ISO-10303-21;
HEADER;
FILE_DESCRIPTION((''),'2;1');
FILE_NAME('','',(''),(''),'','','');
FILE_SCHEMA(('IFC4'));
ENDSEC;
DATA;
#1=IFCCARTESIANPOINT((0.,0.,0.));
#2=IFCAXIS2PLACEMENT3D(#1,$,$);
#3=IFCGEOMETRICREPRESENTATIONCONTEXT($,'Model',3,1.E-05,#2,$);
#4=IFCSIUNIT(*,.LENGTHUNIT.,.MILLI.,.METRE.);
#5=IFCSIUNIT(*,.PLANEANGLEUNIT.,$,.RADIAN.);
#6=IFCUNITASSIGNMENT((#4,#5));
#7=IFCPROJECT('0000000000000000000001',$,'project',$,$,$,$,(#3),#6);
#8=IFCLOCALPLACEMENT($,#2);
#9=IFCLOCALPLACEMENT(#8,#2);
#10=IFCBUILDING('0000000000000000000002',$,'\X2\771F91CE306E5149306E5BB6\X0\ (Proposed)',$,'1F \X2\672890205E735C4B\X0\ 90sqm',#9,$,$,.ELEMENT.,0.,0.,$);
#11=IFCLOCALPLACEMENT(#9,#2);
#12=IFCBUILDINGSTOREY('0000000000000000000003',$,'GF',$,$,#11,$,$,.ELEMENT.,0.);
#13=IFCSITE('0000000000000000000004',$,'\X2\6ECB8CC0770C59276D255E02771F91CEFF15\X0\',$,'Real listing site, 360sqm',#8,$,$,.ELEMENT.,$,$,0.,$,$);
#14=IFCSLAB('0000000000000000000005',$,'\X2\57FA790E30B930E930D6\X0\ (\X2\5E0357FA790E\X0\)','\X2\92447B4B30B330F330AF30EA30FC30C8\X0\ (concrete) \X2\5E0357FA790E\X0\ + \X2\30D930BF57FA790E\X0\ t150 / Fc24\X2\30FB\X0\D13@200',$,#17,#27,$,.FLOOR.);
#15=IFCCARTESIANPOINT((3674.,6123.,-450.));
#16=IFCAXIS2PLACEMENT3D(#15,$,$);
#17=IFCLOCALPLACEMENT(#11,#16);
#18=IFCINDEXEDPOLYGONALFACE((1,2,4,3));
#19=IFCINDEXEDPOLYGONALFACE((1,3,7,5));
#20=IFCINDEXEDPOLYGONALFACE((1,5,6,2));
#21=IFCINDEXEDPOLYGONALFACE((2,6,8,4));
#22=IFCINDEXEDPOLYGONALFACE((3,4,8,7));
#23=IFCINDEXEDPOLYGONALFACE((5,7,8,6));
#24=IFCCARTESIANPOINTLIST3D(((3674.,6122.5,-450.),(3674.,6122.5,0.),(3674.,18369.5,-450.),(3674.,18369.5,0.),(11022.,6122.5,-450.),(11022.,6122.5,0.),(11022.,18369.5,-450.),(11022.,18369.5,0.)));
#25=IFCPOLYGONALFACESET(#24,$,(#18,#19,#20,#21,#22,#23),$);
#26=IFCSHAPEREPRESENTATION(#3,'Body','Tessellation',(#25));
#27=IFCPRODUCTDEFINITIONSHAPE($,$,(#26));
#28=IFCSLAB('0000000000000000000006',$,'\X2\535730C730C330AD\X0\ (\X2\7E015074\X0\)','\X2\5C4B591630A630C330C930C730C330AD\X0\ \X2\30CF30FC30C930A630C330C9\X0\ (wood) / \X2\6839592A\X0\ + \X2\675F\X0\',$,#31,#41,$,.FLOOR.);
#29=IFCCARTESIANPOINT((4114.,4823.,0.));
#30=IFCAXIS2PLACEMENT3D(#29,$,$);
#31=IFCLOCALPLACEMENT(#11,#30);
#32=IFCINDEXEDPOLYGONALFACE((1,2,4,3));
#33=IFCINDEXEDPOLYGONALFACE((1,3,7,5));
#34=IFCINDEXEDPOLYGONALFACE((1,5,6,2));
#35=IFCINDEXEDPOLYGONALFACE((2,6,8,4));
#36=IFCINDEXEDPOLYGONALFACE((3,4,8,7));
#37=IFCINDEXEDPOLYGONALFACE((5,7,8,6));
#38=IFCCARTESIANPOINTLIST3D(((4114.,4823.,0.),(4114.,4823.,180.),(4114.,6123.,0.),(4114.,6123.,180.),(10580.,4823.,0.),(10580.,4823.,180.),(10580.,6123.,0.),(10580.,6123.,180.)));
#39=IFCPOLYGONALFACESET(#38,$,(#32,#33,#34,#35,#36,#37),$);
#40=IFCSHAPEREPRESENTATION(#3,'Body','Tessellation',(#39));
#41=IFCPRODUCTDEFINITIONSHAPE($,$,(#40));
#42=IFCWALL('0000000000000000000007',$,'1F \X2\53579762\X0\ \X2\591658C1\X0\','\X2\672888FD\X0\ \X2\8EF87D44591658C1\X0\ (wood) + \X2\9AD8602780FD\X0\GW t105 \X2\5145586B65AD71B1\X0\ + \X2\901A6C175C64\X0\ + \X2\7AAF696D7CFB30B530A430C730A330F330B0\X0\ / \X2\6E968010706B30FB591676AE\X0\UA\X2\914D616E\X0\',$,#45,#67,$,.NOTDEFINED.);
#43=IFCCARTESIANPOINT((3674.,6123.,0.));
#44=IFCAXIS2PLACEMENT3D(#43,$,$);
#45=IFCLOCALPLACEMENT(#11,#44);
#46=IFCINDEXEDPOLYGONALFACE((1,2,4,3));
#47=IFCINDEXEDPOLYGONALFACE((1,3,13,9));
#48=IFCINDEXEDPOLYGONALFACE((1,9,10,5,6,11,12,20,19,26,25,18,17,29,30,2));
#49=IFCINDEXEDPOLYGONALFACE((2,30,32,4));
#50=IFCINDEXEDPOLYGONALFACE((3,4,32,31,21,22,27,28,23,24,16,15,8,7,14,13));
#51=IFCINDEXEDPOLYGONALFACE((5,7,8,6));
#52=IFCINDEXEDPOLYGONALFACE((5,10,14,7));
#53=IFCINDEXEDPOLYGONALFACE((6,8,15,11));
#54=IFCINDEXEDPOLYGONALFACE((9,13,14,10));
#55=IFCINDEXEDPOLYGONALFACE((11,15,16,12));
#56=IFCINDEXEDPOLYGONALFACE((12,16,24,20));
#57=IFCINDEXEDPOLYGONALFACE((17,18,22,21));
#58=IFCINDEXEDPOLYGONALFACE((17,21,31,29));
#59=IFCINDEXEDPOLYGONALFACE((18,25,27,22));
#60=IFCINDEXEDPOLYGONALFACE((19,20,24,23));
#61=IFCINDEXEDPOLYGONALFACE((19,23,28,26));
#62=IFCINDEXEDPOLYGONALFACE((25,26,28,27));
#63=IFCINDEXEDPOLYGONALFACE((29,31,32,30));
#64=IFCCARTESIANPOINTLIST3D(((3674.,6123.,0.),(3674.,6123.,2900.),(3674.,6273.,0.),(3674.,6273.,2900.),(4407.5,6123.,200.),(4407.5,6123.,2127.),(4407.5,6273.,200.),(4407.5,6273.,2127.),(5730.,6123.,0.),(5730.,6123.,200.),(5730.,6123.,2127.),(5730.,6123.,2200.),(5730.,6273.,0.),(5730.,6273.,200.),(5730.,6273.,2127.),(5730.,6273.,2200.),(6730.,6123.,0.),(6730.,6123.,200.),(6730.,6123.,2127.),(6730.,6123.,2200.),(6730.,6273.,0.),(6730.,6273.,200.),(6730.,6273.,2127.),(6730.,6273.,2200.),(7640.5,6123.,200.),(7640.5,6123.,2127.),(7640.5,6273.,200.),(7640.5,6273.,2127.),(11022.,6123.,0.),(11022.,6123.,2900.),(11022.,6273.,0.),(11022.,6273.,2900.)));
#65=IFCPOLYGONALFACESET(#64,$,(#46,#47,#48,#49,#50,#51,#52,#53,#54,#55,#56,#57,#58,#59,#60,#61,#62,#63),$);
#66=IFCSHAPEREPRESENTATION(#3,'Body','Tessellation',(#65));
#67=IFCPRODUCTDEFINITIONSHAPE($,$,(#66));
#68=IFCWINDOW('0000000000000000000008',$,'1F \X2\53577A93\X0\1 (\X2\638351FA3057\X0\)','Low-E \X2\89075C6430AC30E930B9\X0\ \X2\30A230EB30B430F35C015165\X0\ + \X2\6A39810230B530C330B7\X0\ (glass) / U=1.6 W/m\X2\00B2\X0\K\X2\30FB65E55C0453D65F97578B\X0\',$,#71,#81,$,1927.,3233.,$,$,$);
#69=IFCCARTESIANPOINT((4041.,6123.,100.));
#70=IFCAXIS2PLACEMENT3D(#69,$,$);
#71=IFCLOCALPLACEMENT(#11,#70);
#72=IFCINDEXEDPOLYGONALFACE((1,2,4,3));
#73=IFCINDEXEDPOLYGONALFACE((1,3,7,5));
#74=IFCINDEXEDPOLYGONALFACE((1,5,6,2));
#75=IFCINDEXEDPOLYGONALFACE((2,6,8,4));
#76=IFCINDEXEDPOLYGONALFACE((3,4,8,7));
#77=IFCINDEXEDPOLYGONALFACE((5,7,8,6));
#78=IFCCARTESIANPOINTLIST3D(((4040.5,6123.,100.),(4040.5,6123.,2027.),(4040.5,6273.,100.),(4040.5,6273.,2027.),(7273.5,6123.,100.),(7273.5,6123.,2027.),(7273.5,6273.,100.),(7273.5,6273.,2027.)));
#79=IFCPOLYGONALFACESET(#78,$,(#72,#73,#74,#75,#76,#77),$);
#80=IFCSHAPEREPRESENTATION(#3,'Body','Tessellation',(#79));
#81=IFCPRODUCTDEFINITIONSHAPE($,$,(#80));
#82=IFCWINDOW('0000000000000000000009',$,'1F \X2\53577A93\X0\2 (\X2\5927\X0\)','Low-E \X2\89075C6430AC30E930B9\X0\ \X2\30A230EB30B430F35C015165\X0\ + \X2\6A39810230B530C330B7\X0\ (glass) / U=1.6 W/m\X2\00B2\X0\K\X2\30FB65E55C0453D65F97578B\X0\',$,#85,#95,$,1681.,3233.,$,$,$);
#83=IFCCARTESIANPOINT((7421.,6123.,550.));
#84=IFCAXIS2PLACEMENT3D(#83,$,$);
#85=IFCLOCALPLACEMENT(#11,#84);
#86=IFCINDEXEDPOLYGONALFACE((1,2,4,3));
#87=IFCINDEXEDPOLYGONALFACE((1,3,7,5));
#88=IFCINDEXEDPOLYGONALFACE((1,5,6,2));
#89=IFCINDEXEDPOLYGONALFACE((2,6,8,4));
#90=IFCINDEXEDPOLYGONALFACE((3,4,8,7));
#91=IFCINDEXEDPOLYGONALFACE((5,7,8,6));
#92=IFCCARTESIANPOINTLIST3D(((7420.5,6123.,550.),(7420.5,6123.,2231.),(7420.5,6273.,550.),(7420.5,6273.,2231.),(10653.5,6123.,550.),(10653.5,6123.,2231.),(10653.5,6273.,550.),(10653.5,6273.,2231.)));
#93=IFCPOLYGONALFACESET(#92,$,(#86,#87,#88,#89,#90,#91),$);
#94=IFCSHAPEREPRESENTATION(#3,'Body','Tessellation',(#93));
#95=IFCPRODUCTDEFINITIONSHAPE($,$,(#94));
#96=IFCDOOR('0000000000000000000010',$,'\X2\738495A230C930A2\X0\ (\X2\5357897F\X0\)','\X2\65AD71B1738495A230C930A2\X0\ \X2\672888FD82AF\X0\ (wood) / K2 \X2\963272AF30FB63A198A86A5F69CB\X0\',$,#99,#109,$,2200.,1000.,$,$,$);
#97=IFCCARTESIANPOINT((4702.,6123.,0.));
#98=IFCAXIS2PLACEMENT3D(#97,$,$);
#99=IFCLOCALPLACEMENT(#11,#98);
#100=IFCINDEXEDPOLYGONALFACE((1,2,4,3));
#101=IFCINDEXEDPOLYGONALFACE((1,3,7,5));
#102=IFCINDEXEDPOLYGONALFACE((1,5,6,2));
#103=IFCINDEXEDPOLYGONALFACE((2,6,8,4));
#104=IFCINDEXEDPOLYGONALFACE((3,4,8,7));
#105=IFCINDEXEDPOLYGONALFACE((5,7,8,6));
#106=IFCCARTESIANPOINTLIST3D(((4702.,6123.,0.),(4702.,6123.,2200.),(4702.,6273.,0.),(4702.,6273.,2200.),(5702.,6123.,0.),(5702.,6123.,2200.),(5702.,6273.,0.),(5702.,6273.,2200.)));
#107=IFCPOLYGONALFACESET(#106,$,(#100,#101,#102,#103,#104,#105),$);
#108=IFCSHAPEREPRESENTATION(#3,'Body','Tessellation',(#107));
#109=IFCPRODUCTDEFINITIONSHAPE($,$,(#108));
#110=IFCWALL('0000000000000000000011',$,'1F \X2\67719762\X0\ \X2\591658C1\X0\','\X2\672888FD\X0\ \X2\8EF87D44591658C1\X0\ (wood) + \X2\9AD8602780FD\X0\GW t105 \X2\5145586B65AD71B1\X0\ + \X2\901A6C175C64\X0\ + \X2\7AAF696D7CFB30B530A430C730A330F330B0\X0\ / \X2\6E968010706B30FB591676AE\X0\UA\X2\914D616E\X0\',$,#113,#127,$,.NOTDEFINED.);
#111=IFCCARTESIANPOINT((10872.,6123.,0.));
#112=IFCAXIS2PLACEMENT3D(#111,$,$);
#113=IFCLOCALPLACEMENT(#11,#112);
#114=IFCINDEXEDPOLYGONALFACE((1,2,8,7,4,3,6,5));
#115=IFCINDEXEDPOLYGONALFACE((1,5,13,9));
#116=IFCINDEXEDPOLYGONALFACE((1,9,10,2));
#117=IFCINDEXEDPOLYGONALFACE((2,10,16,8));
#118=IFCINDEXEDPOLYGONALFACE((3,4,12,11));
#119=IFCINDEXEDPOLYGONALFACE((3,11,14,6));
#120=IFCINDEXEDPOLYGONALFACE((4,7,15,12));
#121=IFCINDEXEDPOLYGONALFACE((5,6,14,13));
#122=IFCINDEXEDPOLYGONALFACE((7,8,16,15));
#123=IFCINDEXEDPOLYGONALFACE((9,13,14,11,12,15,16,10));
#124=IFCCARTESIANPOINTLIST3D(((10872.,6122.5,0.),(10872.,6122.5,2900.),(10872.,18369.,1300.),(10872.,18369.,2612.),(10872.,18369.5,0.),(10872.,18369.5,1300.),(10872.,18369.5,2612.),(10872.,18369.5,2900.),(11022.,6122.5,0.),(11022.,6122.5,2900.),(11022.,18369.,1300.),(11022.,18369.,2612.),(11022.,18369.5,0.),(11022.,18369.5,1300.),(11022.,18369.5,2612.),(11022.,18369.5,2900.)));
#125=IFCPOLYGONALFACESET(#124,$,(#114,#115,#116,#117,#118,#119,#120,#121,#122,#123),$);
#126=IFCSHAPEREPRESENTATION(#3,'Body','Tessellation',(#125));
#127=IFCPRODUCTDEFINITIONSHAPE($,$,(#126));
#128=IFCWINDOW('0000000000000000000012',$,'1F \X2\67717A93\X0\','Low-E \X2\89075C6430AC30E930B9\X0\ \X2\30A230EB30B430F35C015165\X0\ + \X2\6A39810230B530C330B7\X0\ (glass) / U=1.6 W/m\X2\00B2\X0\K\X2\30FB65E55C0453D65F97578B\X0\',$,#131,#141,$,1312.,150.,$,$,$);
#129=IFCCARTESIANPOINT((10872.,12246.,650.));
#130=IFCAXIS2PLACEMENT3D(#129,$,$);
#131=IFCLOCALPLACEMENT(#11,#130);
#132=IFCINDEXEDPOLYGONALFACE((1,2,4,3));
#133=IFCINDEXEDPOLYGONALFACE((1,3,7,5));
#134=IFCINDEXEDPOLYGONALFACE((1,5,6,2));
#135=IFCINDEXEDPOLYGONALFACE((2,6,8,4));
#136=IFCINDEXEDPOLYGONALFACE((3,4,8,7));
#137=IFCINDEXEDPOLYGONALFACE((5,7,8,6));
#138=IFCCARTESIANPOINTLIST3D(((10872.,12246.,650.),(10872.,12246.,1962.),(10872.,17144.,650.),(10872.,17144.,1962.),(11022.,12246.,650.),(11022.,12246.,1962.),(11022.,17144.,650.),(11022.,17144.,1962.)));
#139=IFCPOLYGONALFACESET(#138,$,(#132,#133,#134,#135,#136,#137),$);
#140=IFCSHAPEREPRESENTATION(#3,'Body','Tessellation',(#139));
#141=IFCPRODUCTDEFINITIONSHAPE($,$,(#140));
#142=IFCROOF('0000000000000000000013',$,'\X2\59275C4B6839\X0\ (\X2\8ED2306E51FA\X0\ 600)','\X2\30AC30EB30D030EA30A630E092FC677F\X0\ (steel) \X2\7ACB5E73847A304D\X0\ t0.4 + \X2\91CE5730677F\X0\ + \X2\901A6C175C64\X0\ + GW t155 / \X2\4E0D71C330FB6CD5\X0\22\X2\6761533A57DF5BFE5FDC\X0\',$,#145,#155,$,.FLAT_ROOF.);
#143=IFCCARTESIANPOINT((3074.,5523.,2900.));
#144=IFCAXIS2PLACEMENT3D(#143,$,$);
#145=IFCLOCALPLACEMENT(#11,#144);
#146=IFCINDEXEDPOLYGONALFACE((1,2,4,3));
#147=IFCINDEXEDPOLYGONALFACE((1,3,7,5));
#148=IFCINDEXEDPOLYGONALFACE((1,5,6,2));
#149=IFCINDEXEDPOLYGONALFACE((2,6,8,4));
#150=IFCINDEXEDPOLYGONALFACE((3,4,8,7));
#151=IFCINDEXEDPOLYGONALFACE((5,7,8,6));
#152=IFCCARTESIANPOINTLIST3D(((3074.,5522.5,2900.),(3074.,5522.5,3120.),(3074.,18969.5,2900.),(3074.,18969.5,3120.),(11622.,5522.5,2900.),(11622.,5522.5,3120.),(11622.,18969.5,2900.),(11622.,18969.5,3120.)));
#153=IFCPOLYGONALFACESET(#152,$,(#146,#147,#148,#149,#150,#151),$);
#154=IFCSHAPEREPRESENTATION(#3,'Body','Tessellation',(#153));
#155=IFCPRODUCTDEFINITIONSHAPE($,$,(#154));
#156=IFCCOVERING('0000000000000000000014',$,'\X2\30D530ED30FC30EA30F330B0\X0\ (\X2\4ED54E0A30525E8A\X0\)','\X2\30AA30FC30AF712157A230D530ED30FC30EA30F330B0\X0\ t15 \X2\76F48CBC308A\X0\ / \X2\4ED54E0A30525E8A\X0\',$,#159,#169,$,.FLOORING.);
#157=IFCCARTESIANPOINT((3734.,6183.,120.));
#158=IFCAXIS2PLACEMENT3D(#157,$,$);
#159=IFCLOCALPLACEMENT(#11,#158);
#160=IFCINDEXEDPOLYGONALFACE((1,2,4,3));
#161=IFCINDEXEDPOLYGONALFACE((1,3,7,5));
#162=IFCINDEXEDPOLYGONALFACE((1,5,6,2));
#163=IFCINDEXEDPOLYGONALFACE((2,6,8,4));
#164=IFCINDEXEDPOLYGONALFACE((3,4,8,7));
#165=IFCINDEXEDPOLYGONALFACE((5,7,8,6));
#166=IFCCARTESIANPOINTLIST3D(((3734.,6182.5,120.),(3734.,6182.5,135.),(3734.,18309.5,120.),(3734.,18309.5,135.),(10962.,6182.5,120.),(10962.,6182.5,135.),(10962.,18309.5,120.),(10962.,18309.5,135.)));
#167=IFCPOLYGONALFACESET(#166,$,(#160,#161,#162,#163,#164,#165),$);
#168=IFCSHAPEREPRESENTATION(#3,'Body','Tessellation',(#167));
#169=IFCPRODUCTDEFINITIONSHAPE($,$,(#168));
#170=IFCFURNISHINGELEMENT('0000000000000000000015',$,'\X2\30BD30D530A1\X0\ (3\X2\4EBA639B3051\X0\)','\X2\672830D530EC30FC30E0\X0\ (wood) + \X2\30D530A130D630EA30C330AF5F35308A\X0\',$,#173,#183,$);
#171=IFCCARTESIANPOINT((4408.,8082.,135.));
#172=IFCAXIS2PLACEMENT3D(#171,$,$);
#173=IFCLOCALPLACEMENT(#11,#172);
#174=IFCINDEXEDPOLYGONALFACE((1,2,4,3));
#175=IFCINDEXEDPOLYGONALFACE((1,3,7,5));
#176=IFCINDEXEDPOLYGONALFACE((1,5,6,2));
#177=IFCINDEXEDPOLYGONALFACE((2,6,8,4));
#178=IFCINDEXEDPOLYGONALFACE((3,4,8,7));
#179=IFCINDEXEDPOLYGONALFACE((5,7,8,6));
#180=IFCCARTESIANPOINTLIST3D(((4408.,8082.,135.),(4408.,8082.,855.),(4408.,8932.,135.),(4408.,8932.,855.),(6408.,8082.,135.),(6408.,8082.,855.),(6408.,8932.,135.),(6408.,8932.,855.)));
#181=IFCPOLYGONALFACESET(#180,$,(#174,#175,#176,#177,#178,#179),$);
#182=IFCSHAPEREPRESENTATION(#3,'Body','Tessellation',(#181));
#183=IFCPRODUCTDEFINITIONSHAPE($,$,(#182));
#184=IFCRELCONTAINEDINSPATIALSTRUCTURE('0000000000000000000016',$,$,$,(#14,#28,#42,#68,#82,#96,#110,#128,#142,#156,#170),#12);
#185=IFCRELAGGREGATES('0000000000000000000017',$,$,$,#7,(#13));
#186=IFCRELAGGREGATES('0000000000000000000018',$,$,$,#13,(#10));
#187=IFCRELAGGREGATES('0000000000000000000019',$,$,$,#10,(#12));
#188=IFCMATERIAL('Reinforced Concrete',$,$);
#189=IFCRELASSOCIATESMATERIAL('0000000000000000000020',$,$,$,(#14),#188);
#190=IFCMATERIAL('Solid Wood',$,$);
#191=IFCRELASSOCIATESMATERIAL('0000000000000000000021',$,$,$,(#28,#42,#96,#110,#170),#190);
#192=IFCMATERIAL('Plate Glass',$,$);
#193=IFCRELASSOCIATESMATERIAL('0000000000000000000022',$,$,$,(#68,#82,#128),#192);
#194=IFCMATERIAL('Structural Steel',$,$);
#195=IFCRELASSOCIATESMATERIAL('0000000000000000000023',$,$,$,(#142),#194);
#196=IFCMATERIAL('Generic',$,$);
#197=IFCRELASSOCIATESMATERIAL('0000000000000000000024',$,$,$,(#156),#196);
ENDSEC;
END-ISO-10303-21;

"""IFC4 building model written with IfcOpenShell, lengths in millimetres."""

from ifc_helpers import new_model, si_unit, frame, frame_2d, origin, place, context, project, spatial, rectangle, extrude, material, element, fill, save


model = new_model("IFC4")

# Units and contexts
model_context = context("Model", 3, precision=1e-05, world=origin())
ifc_project = project(units=[si_unit("LENGTHUNIT", "METRE", prefix="MILLI"), si_unit("PLANEANGLEUNIT", "RADIAN")], contexts=[model_context])

# Site, building, storey
site_placement = place(None, origin())
site = spatial("IfcSite", under=ifc_project, at=site_placement, Name="滋賀県大津市真野５", ObjectType="Real listing site, 360sqm", CompositionType="ELEMENT", RefElevation=0.0)
building_placement = place(site_placement, origin())
building = spatial("IfcBuilding", under=site, at=building_placement, Name="真野の光の家 (Proposed)", ObjectType="1F 木造平屋 90sqm", CompositionType="ELEMENT", ElevationOfRefHeight=0.0, ElevationOfTerrain=0.0)
storey_placement = place(building_placement, origin())
storey = spatial("IfcBuildingStorey", under=building, at=storey_placement, Name="GF", CompositionType="ELEMENT", Elevation=0.0)

# Slabs
ifc_material_1 = material(Name="Reinforced Concrete")
slab_1_placement = place(storey_placement, frame((3674.0, 6123.0, -450.0)))
element("IfcSlab", 1, at=slab_1_placement, inside=storey, material=ifc_material_1, Name="基礎スラブ (布基礎)", Description="鉄筋コンクリート (concrete) 布基礎 + ベタ基礎 t150 / Fc24・D13@200", PredefinedType="FLOOR", context=model_context, shape_type="SweptSolid", body=[
    extrude(rectangle(XDim=7348.0, YDim=12247.0, at=frame_2d((3674.0, 6123.0))), frame((3674.0, 6123.0, -450.0)), (0.0, 0.0, 1.0), 450.0),
])
ifc_material_2 = material(Name="Solid Wood")
slab_2_placement = place(storey_placement, frame((4114.0, 4823.0, 0.0)))
element("IfcSlab", 2, at=slab_2_placement, inside=storey, material=ifc_material_2, Name="南デッキ (縁側)", Description="屋外ウッドデッキ ハードウッド (wood) / 根太 + 束", PredefinedType="FLOOR", context=model_context, shape_type="SweptSolid", body=[
    extrude(rectangle(XDim=6466.0, YDim=1300.0, at=frame_2d((3233.0, 650.0))), frame((4114.0, 4823.0, 0.0)), (0.0, 0.0, 1.0), 180.0),
])

# Wall, openings, windows, door
wall_1_placement = place(storey_placement, frame((3674.0, 6123.0, 0.0)))
wall_1 = element("IfcWall", 3, at=wall_1_placement, inside=storey, material=ifc_material_2, Name="1F 南面 外壁", Description="木製 軸組外壁 (wood) + 高性能GW t105 充填断熱 + 通気層 + 窯業系サイディング / 準耐火・外皮UA配慮", PredefinedType="NOTDEFINED", context=model_context, shape_type="SweptSolid", body=[
    extrude(rectangle(XDim=7348.0, YDim=150.0, at=frame_2d((3674.0, 75.0))), frame((3674.0, 6123.0, 0.0)), (0.0, 0.0, 1.0), 2900.0),
])
opening_1_placement = place(storey_placement, frame((4041.0, 6123.0, 100.0)))
opening_1 = element("IfcOpeningElement", 4, at=opening_1_placement, cuts=wall_1, PredefinedType="NOTDEFINED", context=model_context, shape_type="SweptSolid", body=[
    extrude(rectangle(XDim=3233.0, YDim=150.0, at=frame_2d((1616.0, 75.0))), frame((4041.0, 6123.0, 100.0)), (0.0, 0.0, 1.0), 1927.0),
])
opening_2_placement = place(storey_placement, frame((7421.0, 6123.0, 550.0)))
opening_2 = element("IfcOpeningElement", 5, at=opening_2_placement, cuts=wall_1, PredefinedType="NOTDEFINED", context=model_context, shape_type="SweptSolid", body=[
    extrude(rectangle(XDim=3233.0, YDim=150.0, at=frame_2d((1616.0, 75.0))), frame((7421.0, 6123.0, 550.0)), (0.0, 0.0, 1.0), 1681.0),
])
opening_3_placement = place(storey_placement, frame((4702.0, 6123.0, 0.0)))
opening_3 = element("IfcOpeningElement", 6, at=opening_3_placement, cuts=wall_1, PredefinedType="NOTDEFINED", context=model_context, shape_type="SweptSolid", body=[
    extrude(rectangle(XDim=1000.0, YDim=150.0, at=frame_2d((500.0, 75.0))), frame((4702.0, 6123.0, 0.0)), (0.0, 0.0, 1.0), 2200.0),
])
ifc_material_3 = material(Name="Plate Glass")
window_1_placement = place(storey_placement, frame((4041.0, 6123.0, 100.0)))
window_1 = element("IfcWindow", 7, at=window_1_placement, inside=storey, material=ifc_material_3, Name="1F 南窓1 (掃出し)", Description="Low-E 複層ガラス アルゴン封入 + 樹脂サッシ (glass) / U=1.6 W/m²K・日射取得型", OverallHeight=1927.0, OverallWidth=3233.0, context=model_context, shape_type="SweptSolid", body=[
    extrude(rectangle(XDim=3233.0, YDim=150.0, at=frame_2d((1616.0, 75.0))), frame((4041.0, 6123.0, 100.0)), (0.0, 0.0, 1.0), 1927.0),
])
fill(opening_1, window_1)
window_2_placement = place(storey_placement, frame((7421.0, 6123.0, 550.0)))
window_2 = element("IfcWindow", 8, at=window_2_placement, inside=storey, material=ifc_material_3, Name="1F 南窓2 (大)", Description="Low-E 複層ガラス アルゴン封入 + 樹脂サッシ (glass) / U=1.6 W/m²K・日射取得型", OverallHeight=1681.0, OverallWidth=3233.0, context=model_context, shape_type="SweptSolid", body=[
    extrude(rectangle(XDim=3233.0, YDim=150.0, at=frame_2d((1616.0, 75.0))), frame((7421.0, 6123.0, 550.0)), (0.0, 0.0, 1.0), 1681.0),
])
fill(opening_2, window_2)
door_placement = place(storey_placement, frame((4702.0, 6123.0, 0.0)))
door = element("IfcDoor", 9, at=door_placement, inside=storey, material=ifc_material_2, Name="玄関ドア (南西)", Description="断熱玄関ドア 木製芯 (wood) / K2 防犯・採風機構", OverallHeight=2200.0, OverallWidth=1000.0, context=model_context, shape_type="SweptSolid", body=[
    extrude(rectangle(XDim=1000.0, YDim=150.0, at=frame_2d((500.0, 75.0))), frame((4702.0, 6123.0, 0.0)), (0.0, 0.0, 1.0), 2200.0),
])
fill(opening_3, door)

# Wall, opening, window
wall_2_placement = place(storey_placement, frame((10872.0, 6123.0, 0.0)))
wall_2 = element("IfcWall", 10, at=wall_2_placement, inside=storey, material=ifc_material_2, Name="1F 東面 外壁", Description="木製 軸組外壁 (wood) + 高性能GW t105 充填断熱 + 通気層 + 窯業系サイディング / 準耐火・外皮UA配慮", PredefinedType="NOTDEFINED", context=model_context, shape_type="SweptSolid", body=[
    extrude(rectangle(XDim=150.0, YDim=12247.0, at=frame_2d((75.0, 6123.0))), frame((10872.0, 6123.0, 0.0)), (0.0, 0.0, 1.0), 2900.0),
])
opening_4_placement = place(storey_placement, frame((10872.0, 12246.0, 650.0)))
opening_4 = element("IfcOpeningElement", 11, at=opening_4_placement, cuts=wall_2, PredefinedType="NOTDEFINED", context=model_context, shape_type="SweptSolid", body=[
    extrude(rectangle(XDim=150.0, YDim=4898.0, at=frame_2d((75.0, 2449.0))), frame((10872.0, 12246.0, 650.0)), (0.0, 0.0, 1.0), 1312.0),
])
window_3_placement = place(storey_placement, frame((10872.0, 12246.0, 650.0)))
window_3 = element("IfcWindow", 12, at=window_3_placement, inside=storey, material=ifc_material_3, Name="1F 東窓", Description="Low-E 複層ガラス アルゴン封入 + 樹脂サッシ (glass) / U=1.6 W/m²K・日射取得型", OverallHeight=1312.0, OverallWidth=150.0, context=model_context, shape_type="SweptSolid", body=[
    extrude(rectangle(XDim=150.0, YDim=4898.0, at=frame_2d((75.0, 2449.0))), frame((10872.0, 12246.0, 650.0)), (0.0, 0.0, 1.0), 1312.0),
])
fill(opening_4, window_3)

# Roof
ifc_material_4 = material(Name="Structural Steel")
roof_placement = place(storey_placement, frame((3074.0, 5523.0, 2900.0)))
element("IfcRoof", 13, at=roof_placement, inside=storey, material=ifc_material_4, Name="大屋根 (軒の出 600)", Description="ガルバリウム鋼板 (steel) 立平葺き t0.4 + 野地板 + 通気層 + GW t155 / 不燃・法22条区域対応", PredefinedType="FLAT_ROOF", context=model_context, shape_type="SweptSolid", body=[
    extrude(rectangle(XDim=8548.0, YDim=13447.0, at=frame_2d((4274.0, 6723.0))), frame((3074.0, 5523.0, 2900.0)), (0.0, 0.0, 1.0), 220.0),
])

# Covering
ifc_material_5 = material(Name="Generic")
covering_placement = place(storey_placement, frame((3734.0, 6183.0, 120.0)))
element("IfcCovering", 14, at=covering_placement, inside=storey, material=ifc_material_5, Name="フローリング (仕上げ床)", Description="オーク無垢フローリング t15 直貼り / 仕上げ床", PredefinedType="FLOORING", context=model_context, shape_type="SweptSolid", body=[
    extrude(rectangle(XDim=7228.0, YDim=12127.0, at=frame_2d((3614.0, 6063.0))), frame((3734.0, 6183.0, 120.0)), (0.0, 0.0, 1.0), 15.0),
])

# Furnishing element
furnishing_1_placement = place(storey_placement, frame((4408.0, 8082.0, 135.0)))
element("IfcFurnishingElement", 15, at=furnishing_1_placement, inside=storey, material=ifc_material_2, Name="ソファ (3人掛け)", Description="木フレーム (wood) + ファブリック張り", context=model_context, shape_type="SweptSolid", body=[
    extrude(rectangle(XDim=2000.0, YDim=850.0, at=frame_2d((1000.0, 425.0))), frame((4408.0, 8082.0, 135.0)), (0.0, 0.0, 1.0), 720.0),
])

save(model, "model.ifc")
